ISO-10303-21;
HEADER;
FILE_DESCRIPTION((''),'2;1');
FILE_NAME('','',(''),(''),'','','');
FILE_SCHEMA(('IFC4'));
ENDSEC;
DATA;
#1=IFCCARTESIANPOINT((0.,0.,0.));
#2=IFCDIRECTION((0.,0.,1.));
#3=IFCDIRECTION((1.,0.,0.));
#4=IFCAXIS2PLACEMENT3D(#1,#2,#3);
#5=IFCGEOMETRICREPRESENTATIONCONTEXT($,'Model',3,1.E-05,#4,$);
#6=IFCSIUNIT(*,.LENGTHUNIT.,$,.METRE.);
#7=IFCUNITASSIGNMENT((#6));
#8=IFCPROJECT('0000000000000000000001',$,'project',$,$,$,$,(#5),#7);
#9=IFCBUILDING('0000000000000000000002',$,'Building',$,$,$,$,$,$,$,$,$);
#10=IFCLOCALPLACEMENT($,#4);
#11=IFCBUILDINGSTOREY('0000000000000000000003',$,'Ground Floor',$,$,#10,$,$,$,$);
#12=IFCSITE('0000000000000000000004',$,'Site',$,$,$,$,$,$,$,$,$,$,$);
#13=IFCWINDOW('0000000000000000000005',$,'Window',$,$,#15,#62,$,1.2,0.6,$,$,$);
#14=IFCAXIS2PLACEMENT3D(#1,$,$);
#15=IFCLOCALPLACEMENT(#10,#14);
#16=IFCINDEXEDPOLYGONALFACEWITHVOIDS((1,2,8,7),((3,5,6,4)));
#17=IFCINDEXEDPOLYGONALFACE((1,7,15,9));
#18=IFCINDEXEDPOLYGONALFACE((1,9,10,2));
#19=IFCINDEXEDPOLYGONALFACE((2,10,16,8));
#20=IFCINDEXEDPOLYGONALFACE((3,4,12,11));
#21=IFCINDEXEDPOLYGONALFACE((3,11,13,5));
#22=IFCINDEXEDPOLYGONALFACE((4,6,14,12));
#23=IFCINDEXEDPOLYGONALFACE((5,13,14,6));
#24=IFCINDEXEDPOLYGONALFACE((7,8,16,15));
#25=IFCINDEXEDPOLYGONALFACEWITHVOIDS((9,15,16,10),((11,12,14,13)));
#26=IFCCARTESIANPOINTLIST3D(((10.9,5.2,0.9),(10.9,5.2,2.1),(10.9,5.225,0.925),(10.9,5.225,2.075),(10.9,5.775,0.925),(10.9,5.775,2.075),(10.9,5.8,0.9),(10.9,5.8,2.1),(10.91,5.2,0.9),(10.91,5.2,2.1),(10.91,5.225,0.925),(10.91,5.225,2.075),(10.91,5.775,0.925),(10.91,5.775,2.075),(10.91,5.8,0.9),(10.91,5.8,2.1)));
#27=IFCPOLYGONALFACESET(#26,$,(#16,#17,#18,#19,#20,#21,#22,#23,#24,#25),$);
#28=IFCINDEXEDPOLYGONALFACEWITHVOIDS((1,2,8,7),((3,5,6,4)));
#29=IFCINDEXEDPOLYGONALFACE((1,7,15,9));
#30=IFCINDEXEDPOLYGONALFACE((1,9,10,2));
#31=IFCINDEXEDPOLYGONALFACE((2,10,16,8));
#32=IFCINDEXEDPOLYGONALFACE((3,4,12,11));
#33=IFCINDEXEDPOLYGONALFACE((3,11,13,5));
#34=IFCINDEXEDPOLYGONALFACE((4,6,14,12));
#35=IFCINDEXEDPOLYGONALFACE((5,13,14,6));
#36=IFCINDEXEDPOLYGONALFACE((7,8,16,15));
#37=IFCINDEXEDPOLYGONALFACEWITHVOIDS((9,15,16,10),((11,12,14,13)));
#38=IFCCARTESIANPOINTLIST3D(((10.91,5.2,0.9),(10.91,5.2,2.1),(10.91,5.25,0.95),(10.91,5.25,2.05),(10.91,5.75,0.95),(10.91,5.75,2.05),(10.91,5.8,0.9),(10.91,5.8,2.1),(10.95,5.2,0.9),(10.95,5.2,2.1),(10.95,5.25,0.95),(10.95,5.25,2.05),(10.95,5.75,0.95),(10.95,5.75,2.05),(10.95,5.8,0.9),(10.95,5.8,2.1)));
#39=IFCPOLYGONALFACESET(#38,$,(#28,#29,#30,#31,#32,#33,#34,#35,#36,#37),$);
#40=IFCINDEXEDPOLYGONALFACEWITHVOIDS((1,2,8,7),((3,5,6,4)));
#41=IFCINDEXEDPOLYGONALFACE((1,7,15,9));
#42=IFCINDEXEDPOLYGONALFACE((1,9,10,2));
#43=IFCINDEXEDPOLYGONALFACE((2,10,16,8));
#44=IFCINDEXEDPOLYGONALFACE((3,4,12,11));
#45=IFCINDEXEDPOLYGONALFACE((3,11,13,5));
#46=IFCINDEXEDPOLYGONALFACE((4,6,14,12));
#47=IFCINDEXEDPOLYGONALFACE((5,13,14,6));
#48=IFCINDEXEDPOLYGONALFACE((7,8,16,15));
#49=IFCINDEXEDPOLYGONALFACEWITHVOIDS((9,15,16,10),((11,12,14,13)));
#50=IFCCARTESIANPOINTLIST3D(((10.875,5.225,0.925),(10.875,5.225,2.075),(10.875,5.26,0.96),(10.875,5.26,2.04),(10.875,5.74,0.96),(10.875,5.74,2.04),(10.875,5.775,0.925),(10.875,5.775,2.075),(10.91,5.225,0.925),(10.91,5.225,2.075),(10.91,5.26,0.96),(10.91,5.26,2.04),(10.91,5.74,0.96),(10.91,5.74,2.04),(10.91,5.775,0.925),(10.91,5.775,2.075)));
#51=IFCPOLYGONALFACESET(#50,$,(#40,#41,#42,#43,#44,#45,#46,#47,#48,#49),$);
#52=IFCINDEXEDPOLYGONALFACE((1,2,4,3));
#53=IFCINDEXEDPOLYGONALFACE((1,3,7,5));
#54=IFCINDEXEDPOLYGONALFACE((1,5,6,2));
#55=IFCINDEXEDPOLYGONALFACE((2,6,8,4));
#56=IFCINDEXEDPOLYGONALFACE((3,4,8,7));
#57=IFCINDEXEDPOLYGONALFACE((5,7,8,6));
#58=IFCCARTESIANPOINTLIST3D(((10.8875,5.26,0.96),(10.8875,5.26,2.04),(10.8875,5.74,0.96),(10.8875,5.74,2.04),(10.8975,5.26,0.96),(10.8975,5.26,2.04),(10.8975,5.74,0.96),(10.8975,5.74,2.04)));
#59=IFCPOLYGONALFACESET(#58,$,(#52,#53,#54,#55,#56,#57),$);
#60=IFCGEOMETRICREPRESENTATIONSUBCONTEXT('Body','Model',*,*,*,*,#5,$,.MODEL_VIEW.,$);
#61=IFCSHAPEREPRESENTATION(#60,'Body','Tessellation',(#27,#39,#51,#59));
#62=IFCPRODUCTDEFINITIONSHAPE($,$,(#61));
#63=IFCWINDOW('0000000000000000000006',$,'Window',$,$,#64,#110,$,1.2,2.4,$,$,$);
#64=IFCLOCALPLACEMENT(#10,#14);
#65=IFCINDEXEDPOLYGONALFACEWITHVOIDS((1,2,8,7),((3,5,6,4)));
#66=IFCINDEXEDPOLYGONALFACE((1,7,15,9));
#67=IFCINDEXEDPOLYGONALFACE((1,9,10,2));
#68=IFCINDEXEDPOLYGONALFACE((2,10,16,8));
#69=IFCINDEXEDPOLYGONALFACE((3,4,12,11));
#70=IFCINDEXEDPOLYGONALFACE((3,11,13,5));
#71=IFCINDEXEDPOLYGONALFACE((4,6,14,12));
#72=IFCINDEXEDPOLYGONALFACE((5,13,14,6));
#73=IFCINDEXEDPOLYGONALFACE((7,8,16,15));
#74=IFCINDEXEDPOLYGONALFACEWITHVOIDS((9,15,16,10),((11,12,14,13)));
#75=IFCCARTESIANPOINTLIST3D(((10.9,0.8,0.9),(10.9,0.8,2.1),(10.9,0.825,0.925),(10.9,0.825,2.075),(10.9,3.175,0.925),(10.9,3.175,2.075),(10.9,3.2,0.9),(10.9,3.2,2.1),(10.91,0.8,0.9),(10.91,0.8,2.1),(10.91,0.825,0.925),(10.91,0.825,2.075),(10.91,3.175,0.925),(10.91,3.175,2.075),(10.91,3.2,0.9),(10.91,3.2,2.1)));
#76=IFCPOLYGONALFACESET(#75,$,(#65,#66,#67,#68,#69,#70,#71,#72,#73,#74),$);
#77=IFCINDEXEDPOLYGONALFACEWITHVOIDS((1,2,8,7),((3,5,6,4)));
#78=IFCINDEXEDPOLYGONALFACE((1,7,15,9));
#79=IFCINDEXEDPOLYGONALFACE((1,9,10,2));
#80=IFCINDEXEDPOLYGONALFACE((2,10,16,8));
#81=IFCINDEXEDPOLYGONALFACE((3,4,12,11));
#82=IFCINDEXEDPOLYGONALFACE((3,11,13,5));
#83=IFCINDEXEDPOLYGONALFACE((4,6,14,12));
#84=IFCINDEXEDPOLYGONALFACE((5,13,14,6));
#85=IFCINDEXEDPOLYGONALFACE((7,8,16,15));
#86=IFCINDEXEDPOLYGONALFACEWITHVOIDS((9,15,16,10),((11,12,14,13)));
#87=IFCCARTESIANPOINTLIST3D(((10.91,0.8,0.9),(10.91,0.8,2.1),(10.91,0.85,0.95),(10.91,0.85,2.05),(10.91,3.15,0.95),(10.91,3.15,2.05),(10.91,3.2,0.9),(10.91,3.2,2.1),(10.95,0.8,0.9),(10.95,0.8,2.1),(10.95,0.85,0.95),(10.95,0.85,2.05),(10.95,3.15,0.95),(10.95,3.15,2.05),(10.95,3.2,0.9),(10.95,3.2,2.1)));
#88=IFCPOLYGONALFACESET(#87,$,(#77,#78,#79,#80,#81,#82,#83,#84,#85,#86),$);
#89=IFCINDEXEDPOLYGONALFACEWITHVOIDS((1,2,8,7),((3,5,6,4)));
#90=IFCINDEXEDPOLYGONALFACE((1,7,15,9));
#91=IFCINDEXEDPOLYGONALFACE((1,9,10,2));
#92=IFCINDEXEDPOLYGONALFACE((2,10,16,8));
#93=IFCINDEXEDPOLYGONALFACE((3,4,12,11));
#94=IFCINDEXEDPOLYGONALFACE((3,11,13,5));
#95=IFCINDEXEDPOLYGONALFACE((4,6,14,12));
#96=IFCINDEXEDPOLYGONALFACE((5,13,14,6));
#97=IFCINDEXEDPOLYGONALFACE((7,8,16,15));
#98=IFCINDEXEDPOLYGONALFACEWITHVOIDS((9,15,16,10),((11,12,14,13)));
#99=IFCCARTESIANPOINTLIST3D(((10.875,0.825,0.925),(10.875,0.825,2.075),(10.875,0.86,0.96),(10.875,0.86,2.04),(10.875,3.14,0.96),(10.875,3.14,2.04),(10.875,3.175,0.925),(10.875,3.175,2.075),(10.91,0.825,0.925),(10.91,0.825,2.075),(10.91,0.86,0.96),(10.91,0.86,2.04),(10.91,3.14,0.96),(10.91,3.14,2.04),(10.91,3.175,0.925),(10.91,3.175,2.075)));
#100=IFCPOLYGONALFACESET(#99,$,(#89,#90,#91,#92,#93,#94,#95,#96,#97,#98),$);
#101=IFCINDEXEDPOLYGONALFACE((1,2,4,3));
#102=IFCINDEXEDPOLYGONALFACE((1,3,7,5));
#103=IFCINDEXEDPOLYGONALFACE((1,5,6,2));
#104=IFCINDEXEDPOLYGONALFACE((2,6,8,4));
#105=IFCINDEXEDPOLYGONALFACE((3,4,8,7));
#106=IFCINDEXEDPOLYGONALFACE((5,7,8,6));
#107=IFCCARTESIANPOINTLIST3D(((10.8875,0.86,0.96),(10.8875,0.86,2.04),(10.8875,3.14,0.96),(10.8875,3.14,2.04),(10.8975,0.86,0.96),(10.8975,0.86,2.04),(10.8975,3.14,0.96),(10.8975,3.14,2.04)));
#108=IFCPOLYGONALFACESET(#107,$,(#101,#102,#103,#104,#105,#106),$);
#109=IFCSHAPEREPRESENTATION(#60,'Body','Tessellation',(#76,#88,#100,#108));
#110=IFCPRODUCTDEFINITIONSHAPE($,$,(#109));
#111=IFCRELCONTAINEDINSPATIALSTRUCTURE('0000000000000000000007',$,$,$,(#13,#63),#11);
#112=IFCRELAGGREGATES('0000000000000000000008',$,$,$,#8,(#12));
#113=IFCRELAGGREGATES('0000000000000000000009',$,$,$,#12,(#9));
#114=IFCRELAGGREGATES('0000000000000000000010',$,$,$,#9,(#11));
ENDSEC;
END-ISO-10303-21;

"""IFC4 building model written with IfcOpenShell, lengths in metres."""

from ifc_helpers import new_model, si_unit, frame, origin_with_axes, place, context, subcontext, project, spatial, line, indexed_curve, outline, extrude, element, save


model = new_model("IFC4")

# Units and contexts
model_context = context("Model", 3, precision=1e-05, world=origin_with_axes())
body_context = subcontext(model_context, "Body", "Model", "MODEL_VIEW")
ifc_project = project(units=[si_unit("LENGTHUNIT", "METRE")], contexts=[model_context])

# Site, building, storey
site = spatial("IfcSite", under=ifc_project, Name="Site")
building = spatial("IfcBuilding", under=site, Name="Building")
storey_placement = place(None, origin_with_axes())
storey = spatial("IfcBuildingStorey", under=building, at=storey_placement, Name="Ground Floor")

# Windows
window_1_placement = place(storey_placement, frame((11.0, 5.2, 0.9), z_axis=(0.0, 0.0, 1.0), x_axis=(0.0, 1.0, 0.0)))
element("IfcWindow", 1, at=window_1_placement, inside=storey, Name="Window", OverallHeight=1.2, OverallWidth=0.6, context=body_context, shape_type="SweptSolid", body=[
    extrude(outline(indexed_curve([(0.0, 0.0), (0.6, 0.0), (0.6, 1.2), (0.0, 1.2)], segments=[line(1, 2, 3, 4, 1)]), holes=[indexed_curve([(0.025, 0.025), (0.575, 0.025), (0.575, 1.175), (0.025, 1.175)], segments=[line(1, 2, 3, 4, 1)])]), frame((0.0, 0.09, 0.0), z_axis=(0.0, -1.0, 0.0), x_axis=(1.0, 0.0, 0.0)), (0.0, 0.0, -1.0), 0.01),
    extrude(outline(indexed_curve([(0.0, 0.0), (0.6, 0.0), (0.6, 1.2), (0.0, 1.2)], segments=[line(1, 2, 3, 4, 1)]), holes=[indexed_curve([(0.05, 0.05), (0.55, 0.05), (0.55, 1.15), (0.05, 1.15)], segments=[line(1, 2, 3, 4, 1)])]), frame((0.0, 0.05, 0.0), z_axis=(0.0, -1.0, 0.0), x_axis=(1.0, 0.0, 0.0)), (0.0, 0.0, -1.0), 0.04),
    extrude(outline(indexed_curve([(0.0, 0.0), (0.55, 0.0), (0.55, 1.15), (0.0, 1.15)], segments=[line(1, 2, 3, 4, 1)]), holes=[indexed_curve([(0.035, 0.035), (0.515, 0.035), (0.515, 1.115), (0.035, 1.115)], segments=[line(1, 2, 3, 4, 1)])]), frame((0.025, 0.09, 0.025), z_axis=(0.0, -1.0, 0.0), x_axis=(1.0, 0.0, 0.0)), (0.0, 0.0, -1.0), 0.035),
    extrude(outline(indexed_curve([(0.035, 0.035), (0.515, 0.035), (0.515, 1.115), (0.035, 1.115)], segments=[line(1, 2, 3, 4, 1)])), frame((0.025, 0.1025, 0.025), z_axis=(0.0, -1.0, 0.0), x_axis=(1.0, 0.0, 0.0)), (0.0, 0.0, -1.0), 0.01),
])
window_2_placement = place(storey_placement, frame((11.0, 0.8, 0.9), z_axis=(0.0, 0.0, 1.0), x_axis=(0.0, 1.0, 0.0)))
element("IfcWindow", 2, at=window_2_placement, inside=storey, Name="Window", OverallHeight=1.2, OverallWidth=2.4, context=body_context, shape_type="SweptSolid", body=[
    extrude(outline(indexed_curve([(0.0, 0.0), (2.4, 0.0), (2.4, 1.2), (0.0, 1.2)], segments=[line(1, 2, 3, 4, 1)]), holes=[indexed_curve([(0.025, 0.025), (2.375, 0.025), (2.375, 1.175), (0.025, 1.175)], segments=[line(1, 2, 3, 4, 1)])]), frame((0.0, 0.09, 0.0), z_axis=(0.0, -1.0, 0.0), x_axis=(1.0, 0.0, 0.0)), (0.0, 0.0, -1.0), 0.01),
    extrude(outline(indexed_curve([(0.0, 0.0), (2.4, 0.0), (2.4, 1.2), (0.0, 1.2)], segments=[line(1, 2, 3, 4, 1)]), holes=[indexed_curve([(0.05, 0.05), (2.35, 0.05), (2.35, 1.15), (0.05, 1.15)], segments=[line(1, 2, 3, 4, 1)])]), frame((0.0, 0.05, 0.0), z_axis=(0.0, -1.0, 0.0), x_axis=(1.0, 0.0, 0.0)), (0.0, 0.0, -1.0), 0.04),
    extrude(outline(indexed_curve([(0.0, 0.0), (2.35, 0.0), (2.35, 1.15), (0.0, 1.15)], segments=[line(1, 2, 3, 4, 1)]), holes=[indexed_curve([(0.035, 0.035), (2.315, 0.035), (2.315, 1.115), (0.035, 1.115)], segments=[line(1, 2, 3, 4, 1)])]), frame((0.025, 0.09, 0.025), z_axis=(0.0, -1.0, 0.0), x_axis=(1.0, 0.0, 0.0)), (0.0, 0.0, -1.0), 0.035),
    extrude(outline(indexed_curve([(0.035, 0.035), (2.315, 0.035), (2.315, 1.115), (0.035, 1.115)], segments=[line(1, 2, 3, 4, 1)])), frame((0.025, 0.1025, 0.025), z_axis=(0.0, -1.0, 0.0), x_axis=(1.0, 0.0, 0.0)), (0.0, 0.0, -1.0), 0.01),
])

save(model, "model.ifc")
